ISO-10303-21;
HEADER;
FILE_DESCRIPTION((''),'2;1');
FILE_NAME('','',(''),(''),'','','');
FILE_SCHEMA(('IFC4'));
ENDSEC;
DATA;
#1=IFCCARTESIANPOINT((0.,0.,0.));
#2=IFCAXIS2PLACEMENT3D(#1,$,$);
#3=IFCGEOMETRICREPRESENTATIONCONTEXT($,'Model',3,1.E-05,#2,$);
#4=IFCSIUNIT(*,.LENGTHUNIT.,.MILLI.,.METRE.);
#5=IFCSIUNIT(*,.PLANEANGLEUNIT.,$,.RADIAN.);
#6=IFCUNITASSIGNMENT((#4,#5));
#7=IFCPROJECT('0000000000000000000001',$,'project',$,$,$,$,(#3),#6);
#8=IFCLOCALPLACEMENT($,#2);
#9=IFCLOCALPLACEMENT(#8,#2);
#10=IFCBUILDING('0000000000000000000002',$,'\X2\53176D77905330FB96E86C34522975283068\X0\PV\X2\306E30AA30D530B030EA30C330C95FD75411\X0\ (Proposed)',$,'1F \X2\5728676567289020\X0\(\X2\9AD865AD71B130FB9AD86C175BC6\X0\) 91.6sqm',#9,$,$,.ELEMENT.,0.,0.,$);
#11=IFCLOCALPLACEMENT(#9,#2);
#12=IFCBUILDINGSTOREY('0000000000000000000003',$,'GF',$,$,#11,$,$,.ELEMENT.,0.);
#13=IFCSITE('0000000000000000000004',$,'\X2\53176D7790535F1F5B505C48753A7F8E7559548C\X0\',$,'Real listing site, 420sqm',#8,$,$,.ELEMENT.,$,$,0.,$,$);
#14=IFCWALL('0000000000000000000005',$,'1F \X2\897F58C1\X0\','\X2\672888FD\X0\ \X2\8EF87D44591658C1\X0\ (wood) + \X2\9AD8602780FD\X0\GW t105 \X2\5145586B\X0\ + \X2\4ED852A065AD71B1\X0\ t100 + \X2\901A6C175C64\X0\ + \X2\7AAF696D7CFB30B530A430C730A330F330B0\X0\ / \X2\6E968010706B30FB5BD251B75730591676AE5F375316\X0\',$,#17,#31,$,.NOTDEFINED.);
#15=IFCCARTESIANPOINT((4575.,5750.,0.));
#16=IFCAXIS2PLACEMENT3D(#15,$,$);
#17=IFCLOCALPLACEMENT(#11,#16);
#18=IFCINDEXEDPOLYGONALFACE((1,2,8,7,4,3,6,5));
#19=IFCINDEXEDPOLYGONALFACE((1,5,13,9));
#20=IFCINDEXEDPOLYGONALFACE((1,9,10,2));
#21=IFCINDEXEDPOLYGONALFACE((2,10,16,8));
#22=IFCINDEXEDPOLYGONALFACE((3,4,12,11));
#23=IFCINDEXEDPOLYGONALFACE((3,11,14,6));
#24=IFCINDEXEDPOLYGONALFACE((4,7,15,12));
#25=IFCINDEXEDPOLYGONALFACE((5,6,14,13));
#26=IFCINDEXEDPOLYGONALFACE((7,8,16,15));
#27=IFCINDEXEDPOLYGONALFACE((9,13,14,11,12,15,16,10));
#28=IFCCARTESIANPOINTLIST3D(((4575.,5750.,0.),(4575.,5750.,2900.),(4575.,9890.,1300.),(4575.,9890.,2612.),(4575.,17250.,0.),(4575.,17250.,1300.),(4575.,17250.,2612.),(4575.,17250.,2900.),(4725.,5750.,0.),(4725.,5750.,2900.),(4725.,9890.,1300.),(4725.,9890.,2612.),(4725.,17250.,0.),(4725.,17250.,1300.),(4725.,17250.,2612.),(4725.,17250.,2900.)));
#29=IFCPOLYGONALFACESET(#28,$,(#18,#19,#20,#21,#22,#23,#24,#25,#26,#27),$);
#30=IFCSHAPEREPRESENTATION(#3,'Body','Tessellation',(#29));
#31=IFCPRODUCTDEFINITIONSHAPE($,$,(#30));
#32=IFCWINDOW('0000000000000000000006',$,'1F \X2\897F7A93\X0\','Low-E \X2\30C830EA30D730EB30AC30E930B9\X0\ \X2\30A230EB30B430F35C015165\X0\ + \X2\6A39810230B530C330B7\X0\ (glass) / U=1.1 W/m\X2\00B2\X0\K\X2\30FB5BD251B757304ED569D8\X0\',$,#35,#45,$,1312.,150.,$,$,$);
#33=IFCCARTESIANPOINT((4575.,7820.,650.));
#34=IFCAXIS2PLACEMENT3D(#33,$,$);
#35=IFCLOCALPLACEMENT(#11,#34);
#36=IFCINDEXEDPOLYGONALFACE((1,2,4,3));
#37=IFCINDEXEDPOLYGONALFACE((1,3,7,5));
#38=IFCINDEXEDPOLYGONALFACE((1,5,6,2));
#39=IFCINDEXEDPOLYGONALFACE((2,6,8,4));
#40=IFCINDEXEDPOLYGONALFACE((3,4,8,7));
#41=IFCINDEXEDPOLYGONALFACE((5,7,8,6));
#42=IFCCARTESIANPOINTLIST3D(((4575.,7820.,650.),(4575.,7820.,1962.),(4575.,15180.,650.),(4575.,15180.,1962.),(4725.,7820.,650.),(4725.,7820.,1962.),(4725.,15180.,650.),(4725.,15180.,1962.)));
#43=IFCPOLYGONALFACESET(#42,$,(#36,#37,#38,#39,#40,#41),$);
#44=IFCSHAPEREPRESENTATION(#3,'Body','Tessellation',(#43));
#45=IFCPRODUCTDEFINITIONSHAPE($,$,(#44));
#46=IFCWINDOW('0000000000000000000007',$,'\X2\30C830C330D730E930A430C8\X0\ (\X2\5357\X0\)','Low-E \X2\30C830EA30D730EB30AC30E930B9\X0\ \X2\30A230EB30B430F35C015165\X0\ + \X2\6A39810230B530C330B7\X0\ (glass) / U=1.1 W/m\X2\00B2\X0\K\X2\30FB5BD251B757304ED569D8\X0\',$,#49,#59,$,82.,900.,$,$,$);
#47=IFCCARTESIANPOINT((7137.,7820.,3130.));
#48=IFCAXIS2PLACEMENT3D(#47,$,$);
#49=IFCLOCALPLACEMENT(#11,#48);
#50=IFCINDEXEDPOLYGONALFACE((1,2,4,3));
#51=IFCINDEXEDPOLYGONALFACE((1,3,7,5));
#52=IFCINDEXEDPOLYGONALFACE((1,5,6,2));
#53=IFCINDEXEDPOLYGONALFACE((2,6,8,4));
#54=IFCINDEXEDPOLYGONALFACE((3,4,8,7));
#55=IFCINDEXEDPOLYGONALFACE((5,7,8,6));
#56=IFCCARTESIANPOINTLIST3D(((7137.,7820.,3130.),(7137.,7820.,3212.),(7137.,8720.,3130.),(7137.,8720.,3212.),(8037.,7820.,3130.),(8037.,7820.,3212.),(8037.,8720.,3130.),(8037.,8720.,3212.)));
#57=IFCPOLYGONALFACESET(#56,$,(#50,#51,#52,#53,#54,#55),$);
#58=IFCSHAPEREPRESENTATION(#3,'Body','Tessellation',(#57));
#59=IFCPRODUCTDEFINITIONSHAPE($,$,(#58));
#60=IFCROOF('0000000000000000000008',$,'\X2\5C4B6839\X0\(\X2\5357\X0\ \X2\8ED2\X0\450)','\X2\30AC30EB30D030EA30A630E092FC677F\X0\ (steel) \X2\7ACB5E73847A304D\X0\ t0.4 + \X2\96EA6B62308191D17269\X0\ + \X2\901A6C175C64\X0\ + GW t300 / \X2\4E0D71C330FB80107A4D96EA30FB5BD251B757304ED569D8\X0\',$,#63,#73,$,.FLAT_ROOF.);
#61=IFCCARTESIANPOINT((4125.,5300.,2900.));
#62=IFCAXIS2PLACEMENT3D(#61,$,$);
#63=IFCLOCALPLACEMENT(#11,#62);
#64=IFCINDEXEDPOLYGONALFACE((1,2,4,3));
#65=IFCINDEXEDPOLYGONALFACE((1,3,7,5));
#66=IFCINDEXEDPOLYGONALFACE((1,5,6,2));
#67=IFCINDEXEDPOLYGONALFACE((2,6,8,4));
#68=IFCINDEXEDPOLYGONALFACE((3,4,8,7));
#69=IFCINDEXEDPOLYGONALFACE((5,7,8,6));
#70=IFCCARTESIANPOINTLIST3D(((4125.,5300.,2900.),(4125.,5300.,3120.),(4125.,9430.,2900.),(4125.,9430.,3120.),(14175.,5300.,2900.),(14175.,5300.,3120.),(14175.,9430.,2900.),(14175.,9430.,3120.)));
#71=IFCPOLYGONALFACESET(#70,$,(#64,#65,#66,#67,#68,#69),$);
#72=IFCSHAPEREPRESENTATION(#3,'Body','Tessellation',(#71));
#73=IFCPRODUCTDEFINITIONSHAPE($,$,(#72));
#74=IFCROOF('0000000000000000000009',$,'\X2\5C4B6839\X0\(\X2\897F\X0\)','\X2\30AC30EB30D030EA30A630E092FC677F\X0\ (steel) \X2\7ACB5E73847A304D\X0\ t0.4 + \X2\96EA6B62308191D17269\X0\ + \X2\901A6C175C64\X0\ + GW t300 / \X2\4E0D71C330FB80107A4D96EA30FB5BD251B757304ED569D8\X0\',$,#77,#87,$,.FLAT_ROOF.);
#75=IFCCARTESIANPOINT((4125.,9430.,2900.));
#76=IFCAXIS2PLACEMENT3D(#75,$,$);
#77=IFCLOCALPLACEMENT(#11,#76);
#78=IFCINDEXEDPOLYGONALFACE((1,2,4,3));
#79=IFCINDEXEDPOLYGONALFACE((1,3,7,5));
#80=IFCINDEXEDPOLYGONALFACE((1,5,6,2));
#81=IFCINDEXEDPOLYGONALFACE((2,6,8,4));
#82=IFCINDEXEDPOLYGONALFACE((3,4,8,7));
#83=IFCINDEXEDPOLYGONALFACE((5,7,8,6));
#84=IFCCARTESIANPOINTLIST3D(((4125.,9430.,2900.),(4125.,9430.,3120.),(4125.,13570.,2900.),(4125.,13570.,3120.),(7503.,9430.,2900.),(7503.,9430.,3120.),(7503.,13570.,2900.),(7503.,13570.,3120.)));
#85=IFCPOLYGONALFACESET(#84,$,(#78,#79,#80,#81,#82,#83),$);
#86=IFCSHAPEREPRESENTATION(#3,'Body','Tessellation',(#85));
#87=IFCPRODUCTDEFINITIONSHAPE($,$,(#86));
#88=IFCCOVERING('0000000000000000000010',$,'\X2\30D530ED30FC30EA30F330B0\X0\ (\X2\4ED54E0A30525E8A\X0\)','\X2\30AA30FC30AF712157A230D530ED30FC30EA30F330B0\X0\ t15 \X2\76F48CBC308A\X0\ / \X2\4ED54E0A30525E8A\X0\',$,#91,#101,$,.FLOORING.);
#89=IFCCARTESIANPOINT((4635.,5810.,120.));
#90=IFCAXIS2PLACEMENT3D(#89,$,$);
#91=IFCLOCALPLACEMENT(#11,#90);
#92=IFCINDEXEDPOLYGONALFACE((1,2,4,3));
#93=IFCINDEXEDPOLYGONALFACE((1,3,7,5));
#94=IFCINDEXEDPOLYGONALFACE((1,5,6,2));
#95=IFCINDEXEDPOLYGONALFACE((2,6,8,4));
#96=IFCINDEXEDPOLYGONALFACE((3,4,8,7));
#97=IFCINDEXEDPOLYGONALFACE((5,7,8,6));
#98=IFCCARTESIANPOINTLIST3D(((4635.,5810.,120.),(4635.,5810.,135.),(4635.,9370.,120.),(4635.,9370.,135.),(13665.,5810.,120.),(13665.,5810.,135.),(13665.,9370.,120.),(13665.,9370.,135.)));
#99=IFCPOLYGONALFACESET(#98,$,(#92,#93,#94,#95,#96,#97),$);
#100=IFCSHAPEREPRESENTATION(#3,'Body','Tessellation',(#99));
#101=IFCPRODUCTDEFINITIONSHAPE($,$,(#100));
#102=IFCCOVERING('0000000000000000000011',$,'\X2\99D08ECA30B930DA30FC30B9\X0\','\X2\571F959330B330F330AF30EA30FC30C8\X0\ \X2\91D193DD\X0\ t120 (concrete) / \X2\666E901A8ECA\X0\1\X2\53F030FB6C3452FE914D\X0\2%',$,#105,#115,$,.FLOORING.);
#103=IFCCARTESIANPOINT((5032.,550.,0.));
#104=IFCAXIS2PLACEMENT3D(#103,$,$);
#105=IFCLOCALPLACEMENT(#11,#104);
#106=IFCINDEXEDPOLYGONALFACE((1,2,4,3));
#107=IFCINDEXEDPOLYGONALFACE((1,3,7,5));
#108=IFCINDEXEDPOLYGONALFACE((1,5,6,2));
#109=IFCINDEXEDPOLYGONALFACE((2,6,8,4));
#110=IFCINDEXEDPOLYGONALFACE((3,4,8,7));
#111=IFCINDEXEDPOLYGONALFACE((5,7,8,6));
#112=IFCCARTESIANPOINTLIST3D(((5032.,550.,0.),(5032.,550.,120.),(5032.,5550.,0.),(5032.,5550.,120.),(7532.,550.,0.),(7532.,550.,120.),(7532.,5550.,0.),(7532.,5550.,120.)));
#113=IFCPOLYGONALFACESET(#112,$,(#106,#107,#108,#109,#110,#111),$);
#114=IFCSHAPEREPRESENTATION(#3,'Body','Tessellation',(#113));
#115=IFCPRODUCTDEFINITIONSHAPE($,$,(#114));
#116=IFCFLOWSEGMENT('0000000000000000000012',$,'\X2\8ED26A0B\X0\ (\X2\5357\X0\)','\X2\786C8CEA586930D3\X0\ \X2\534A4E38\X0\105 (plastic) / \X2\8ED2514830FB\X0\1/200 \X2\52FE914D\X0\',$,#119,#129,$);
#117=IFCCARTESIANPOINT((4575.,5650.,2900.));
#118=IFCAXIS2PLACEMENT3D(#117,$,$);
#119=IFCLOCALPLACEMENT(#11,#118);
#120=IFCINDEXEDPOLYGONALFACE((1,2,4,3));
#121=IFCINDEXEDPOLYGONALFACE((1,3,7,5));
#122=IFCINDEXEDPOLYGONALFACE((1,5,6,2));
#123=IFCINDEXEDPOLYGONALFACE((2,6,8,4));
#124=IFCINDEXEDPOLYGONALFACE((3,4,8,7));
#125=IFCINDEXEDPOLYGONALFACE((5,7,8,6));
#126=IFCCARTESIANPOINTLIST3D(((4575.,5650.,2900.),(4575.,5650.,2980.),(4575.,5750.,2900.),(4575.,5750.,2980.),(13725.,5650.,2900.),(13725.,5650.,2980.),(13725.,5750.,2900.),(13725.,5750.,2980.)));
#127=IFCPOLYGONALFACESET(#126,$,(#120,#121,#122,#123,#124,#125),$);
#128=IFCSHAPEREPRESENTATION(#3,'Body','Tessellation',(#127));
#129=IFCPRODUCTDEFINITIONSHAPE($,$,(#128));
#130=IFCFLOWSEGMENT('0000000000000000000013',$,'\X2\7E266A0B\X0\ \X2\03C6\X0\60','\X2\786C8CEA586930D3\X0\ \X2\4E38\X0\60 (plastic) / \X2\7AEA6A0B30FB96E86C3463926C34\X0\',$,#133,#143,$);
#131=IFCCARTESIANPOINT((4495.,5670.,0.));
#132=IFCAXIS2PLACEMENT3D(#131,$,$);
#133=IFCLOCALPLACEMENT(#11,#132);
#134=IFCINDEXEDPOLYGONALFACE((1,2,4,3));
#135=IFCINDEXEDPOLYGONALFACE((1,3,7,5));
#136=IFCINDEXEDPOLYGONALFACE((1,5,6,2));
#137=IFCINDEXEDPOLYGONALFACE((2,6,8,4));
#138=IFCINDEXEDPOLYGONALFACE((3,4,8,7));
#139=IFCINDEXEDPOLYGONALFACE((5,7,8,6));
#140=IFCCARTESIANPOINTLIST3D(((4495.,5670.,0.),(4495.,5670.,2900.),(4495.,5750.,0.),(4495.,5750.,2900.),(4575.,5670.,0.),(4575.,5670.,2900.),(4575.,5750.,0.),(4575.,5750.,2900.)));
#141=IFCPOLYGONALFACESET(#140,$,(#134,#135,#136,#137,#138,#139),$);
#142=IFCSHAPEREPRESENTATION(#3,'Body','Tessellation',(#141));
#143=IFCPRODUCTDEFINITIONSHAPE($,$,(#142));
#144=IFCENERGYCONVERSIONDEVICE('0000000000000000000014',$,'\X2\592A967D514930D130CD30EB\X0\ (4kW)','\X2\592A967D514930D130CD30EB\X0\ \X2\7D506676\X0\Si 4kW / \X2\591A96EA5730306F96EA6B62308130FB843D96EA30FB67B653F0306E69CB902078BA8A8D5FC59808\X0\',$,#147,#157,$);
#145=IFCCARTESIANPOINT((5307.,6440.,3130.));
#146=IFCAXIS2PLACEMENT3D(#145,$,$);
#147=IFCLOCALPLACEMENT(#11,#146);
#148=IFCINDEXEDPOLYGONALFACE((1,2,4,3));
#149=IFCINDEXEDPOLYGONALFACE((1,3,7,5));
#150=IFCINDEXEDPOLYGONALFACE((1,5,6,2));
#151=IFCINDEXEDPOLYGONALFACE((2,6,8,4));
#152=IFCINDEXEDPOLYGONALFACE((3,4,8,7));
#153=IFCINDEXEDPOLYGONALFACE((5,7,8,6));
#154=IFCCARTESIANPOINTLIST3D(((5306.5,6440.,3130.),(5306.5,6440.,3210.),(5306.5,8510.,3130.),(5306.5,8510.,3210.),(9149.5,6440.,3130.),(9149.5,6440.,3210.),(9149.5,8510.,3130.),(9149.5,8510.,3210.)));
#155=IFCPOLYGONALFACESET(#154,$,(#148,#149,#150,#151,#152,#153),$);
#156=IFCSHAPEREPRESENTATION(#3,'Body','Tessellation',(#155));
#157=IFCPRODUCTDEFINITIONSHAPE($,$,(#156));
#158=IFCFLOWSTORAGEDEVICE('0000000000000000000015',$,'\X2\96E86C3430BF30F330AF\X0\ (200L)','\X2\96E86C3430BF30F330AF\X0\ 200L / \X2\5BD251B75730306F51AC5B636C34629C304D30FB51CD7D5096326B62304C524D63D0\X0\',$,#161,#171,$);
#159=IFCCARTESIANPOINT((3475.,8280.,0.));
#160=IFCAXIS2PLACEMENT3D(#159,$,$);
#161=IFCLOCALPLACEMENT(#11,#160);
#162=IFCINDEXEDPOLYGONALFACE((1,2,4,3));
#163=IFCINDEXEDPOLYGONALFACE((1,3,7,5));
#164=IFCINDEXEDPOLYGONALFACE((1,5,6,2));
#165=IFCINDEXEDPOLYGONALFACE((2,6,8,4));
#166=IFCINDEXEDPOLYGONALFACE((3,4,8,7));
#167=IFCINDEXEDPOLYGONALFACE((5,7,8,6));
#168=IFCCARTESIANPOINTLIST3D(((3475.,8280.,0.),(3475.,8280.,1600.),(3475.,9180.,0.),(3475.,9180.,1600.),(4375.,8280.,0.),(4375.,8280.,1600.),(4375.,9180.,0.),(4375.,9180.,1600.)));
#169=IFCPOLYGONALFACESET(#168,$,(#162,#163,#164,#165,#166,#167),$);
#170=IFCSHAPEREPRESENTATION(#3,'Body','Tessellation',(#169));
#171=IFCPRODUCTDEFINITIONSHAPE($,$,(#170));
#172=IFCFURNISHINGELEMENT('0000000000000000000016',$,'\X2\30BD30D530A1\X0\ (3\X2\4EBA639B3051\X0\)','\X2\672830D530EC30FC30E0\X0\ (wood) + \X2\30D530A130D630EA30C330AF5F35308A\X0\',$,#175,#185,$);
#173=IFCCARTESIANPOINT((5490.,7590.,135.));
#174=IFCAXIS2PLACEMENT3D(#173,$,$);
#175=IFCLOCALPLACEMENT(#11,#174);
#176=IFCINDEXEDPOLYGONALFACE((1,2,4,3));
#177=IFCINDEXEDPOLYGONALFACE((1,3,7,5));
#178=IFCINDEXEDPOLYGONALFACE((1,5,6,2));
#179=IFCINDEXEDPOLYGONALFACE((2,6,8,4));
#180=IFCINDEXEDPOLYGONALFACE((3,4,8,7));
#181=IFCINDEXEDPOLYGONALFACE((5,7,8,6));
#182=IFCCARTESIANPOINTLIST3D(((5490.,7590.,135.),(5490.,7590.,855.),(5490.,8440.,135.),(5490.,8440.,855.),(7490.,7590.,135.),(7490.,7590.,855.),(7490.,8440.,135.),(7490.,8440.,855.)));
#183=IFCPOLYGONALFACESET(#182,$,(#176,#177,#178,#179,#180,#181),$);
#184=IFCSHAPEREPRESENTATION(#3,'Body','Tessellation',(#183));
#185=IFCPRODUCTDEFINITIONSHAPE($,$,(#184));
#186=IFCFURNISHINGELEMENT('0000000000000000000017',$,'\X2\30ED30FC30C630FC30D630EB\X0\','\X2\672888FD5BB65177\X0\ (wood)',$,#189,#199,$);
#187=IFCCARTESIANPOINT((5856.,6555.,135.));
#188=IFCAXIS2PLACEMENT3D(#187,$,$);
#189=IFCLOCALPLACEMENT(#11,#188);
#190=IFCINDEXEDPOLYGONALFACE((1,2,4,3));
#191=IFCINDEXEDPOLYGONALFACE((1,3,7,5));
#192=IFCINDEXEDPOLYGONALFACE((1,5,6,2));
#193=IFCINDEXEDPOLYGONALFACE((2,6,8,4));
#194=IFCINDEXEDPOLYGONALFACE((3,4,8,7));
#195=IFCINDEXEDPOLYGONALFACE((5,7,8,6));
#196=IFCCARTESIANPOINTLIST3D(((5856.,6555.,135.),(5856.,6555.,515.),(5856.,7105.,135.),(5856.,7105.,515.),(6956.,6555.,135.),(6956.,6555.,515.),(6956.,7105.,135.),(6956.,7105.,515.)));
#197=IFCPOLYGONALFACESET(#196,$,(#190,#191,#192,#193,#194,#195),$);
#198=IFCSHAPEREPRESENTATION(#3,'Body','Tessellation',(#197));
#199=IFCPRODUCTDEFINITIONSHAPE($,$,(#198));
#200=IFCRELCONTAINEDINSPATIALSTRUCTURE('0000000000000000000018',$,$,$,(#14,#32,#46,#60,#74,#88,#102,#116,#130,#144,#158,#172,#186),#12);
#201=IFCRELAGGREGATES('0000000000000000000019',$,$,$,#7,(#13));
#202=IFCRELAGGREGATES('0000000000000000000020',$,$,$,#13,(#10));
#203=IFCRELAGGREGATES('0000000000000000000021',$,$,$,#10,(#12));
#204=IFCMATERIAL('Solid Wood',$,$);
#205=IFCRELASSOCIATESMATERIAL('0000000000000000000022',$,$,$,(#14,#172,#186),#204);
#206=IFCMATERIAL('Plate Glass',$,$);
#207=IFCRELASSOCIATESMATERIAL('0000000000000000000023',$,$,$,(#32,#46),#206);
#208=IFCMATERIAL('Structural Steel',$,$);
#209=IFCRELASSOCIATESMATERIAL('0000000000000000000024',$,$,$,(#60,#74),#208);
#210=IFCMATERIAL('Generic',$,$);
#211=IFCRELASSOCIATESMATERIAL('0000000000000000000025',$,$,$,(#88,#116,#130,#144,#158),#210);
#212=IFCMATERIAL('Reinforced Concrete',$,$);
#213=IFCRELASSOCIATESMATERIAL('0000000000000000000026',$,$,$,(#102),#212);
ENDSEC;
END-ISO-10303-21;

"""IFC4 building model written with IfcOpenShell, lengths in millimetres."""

from ifc_helpers import new_model, si_unit, frame, frame_2d, origin, place, context, project, spatial, rectangle, extrude, material, element, fill, save


model = new_model("IFC4")

# Units and contexts
model_context = context("Model", 3, precision=1e-05, world=origin())
ifc_project = project(units=[si_unit("LENGTHUNIT", "METRE", prefix="MILLI"), si_unit("PLANEANGLEUNIT", "RADIAN")], contexts=[model_context])

# Site, building, storey
site_placement = place(None, origin())
site = spatial("IfcSite", under=ifc_project, at=site_placement, Name="北海道弟子屈町美留和", ObjectType="Real listing site, 420sqm", CompositionType="ELEMENT", RefElevation=0.0)
building_placement = place(site_placement, origin())
building = spatial("IfcBuilding", under=site, at=building_placement, Name="北海道・雨水利用とPVのオフグリッド志向 (Proposed)", ObjectType="1F 在来木造(高断熱・高気密) 91.6sqm", CompositionType="ELEMENT", ElevationOfRefHeight=0.0, ElevationOfTerrain=0.0)
storey_placement = place(building_placement, origin())
storey = spatial("IfcBuildingStorey", under=building, at=storey_placement, Name="GF", CompositionType="ELEMENT", Elevation=0.0)

# Shared definitions
ifc_material_1 = material(Name="Solid Wood")

# Shared definitions
ifc_material_2 = material(Name="Reinforced Concrete")

# Shared definitions
ifc_material_3 = material(Name="Plate Glass")

# Wall, opening, window
wall_1_placement = place(storey_placement, frame((4575.0, 5750.0, 0.0)))
wall_1 = element("IfcWall", 1, at=wall_1_placement, inside=storey, material=ifc_material_1, Name="1F 西壁", Description="木製 軸組外壁 (wood) + 高性能GW t105 充填 + 付加断熱 t100 + 通気層 + 窯業系サイディング / 準耐火・寒冷地外皮強化", PredefinedType="NOTDEFINED", context=model_context, shape_type="SweptSolid", body=[
    extrude(rectangle(XDim=150.0, YDim=11500.0, at=frame_2d((75.0, 5750.0))), frame((4575.0, 5750.0, 0.0)), (0.0, 0.0, 1.0), 2900.0),
])
opening_1_placement = place(storey_placement, frame((4575.0, 7820.0, 650.0)))
opening_1 = element("IfcOpeningElement", 2, at=opening_1_placement, cuts=wall_1, PredefinedType="NOTDEFINED", context=model_context, shape_type="SweptSolid", body=[
    extrude(rectangle(XDim=150.0, YDim=7360.0, at=frame_2d((75.0, 3680.0))), frame((4575.0, 7820.0, 650.0)), (0.0, 0.0, 1.0), 1312.0),
])
window_1_placement = place(storey_placement, frame((4575.0, 7820.0, 650.0)))
window_1 = element("IfcWindow", 3, at=window_1_placement, inside=storey, material=ifc_material_3, Name="1F 西窓", Description="Low-E トリプルガラス アルゴン封入 + 樹脂サッシ (glass) / U=1.1 W/m²K・寒冷地仕様", OverallHeight=1312.0, OverallWidth=150.0, context=model_context, shape_type="SweptSolid", body=[
    extrude(rectangle(XDim=150.0, YDim=7360.0, at=frame_2d((75.0, 3680.0))), frame((4575.0, 7820.0, 650.0)), (0.0, 0.0, 1.0), 1312.0),
])
fill(opening_1, window_1)

# Window
window_2_placement = place(storey_placement, frame((7137.0, 7820.0, 3130.0)))
element("IfcWindow", 4, at=window_2_placement, inside=storey, material=ifc_material_3, Name="トップライト (南)", Description="Low-E トリプルガラス アルゴン封入 + 樹脂サッシ (glass) / U=1.1 W/m²K・寒冷地仕様", OverallHeight=82.0, OverallWidth=900.0, context=model_context, shape_type="SweptSolid", body=[
    extrude(rectangle(XDim=900.0, YDim=900.0, at=frame_2d((450.0, 450.0))), frame((7137.0, 7820.0, 3130.0)), (0.0, 0.0, 1.0), 82.0),
])

# Roofs
ifc_material_4 = material(Name="Structural Steel")
roof_1_placement = place(storey_placement, frame((4125.0, 5300.0, 2900.0)))
element("IfcRoof", 5, at=roof_1_placement, inside=storey, material=ifc_material_4, Name="屋根(南 軒450)", Description="ガルバリウム鋼板 (steel) 立平葺き t0.4 + 雪止め金物 + 通気層 + GW t300 / 不燃・耐積雪・寒冷地仕様", PredefinedType="FLAT_ROOF", context=model_context, shape_type="SweptSolid", body=[
    extrude(rectangle(XDim=10050.0, YDim=4130.0, at=frame_2d((5025.0, 2065.0))), frame((4125.0, 5300.0, 2900.0)), (0.0, 0.0, 1.0), 220.0),
])
roof_2_placement = place(storey_placement, frame((4125.0, 9430.0, 2900.0)))
element("IfcRoof", 6, at=roof_2_placement, inside=storey, material=ifc_material_4, Name="屋根(西)", Description="ガルバリウム鋼板 (steel) 立平葺き t0.4 + 雪止め金物 + 通気層 + GW t300 / 不燃・耐積雪・寒冷地仕様", PredefinedType="FLAT_ROOF", context=model_context, shape_type="SweptSolid", body=[
    extrude(rectangle(XDim=3378.0, YDim=4140.0, at=frame_2d((1689.0, 2070.0))), frame((4125.0, 9430.0, 2900.0)), (0.0, 0.0, 1.0), 220.0),
])

# Coverings
ifc_material_5 = material(Name="Generic")
covering_1_placement = place(storey_placement, frame((4635.0, 5810.0, 120.0)))
element("IfcCovering", 7, at=covering_1_placement, inside=storey, material=ifc_material_5, Name="フローリング (仕上げ床)", Description="オーク無垢フローリング t15 直貼り / 仕上げ床", PredefinedType="FLOORING", context=model_context, shape_type="SweptSolid", body=[
    extrude(rectangle(XDim=9030.0, YDim=3560.0, at=frame_2d((4515.0, 1780.0))), frame((4635.0, 5810.0, 120.0)), (0.0, 0.0, 1.0), 15.0),
])
covering_2_placement = place(storey_placement, frame((5032.0, 550.0, 0.0)))
element("IfcCovering", 8, at=covering_2_placement, inside=storey, material=ifc_material_2, Name="駐車スペース", Description="土間コンクリート 金鏝 t120 (concrete) / 普通車1台・水勾配2%", PredefinedType="FLOORING", context=model_context, shape_type="SweptSolid", body=[
    extrude(rectangle(XDim=2500.0, YDim=5000.0, at=frame_2d((1250.0, 2500.0))), frame((5032.0, 550.0, 0.0)), (0.0, 0.0, 1.0), 120.0),
])

# Flow segments
flow_segment_1_placement = place(storey_placement, frame((4575.0, 5650.0, 2900.0)))
element("IfcFlowSegment", 9, at=flow_segment_1_placement, inside=storey, material=ifc_material_5, Name="軒樋 (南)", Description="硬質塩ビ 半丸105 (plastic) / 軒先・1/200 勾配", context=model_context, shape_type="SweptSolid", body=[
    extrude(rectangle(XDim=9150.0, YDim=100.0, at=frame_2d((4575.0, 50.0))), frame((4575.0, 5650.0, 2900.0)), (0.0, 0.0, 1.0), 80.0),
])
flow_segment_2_placement = place(storey_placement, frame((4495.0, 5670.0, 0.0)))
element("IfcFlowSegment", 10, at=flow_segment_2_placement, inside=storey, material=ifc_material_5, Name="縦樋 φ60", Description="硬質塩ビ 丸60 (plastic) / 竪樋・雨水排水", context=model_context, shape_type="SweptSolid", body=[
    extrude(rectangle(XDim=80.0, YDim=80.0, at=frame_2d((40.0, 40.0))), frame((4495.0, 5670.0, 0.0)), (0.0, 0.0, 1.0), 2900.0),
])

# Energy conversion device
energy_conversion_device_placement = place(storey_placement, frame((5307.0, 6440.0, 3130.0)))
element("IfcEnergyConversionDevice", 11, at=energy_conversion_device_placement, inside=storey, material=ifc_material_5, Name="太陽光パネル (4kW)", Description="太陽光パネル 結晶Si 4kW / 多雪地は雪止め・落雪・架台の構造確認必須", context=model_context, shape_type="SweptSolid", body=[
    extrude(rectangle(XDim=3843.0, YDim=2070.0, at=frame_2d((1921.0, 1035.0))), frame((5307.0, 6440.0, 3130.0)), (0.0, 0.0, 1.0), 80.0),
])

# Flow storage device
flow_storage_device_placement = place(storey_placement, frame((3475.0, 8280.0, 0.0)))
element("IfcFlowStorageDevice", 12, at=flow_storage_device_placement, inside=storey, material=ifc_material_5, Name="雨水タンク (200L)", Description="雨水タンク 200L / 寒冷地は冬季水抜き・凍結防止が前提", context=model_context, shape_type="SweptSolid", body=[
    extrude(rectangle(XDim=900.0, YDim=900.0, at=frame_2d((450.0, 450.0))), frame((3475.0, 8280.0, 0.0)), (0.0, 0.0, 1.0), 1600.0),
])

# Furnishing elements
furnishing_1_placement = place(storey_placement, frame((5490.0, 7590.0, 135.0)))
element("IfcFurnishingElement", 13, at=furnishing_1_placement, inside=storey, material=ifc_material_1, Name="ソファ (3人掛け)", Description="木フレーム (wood) + ファブリック張り", context=model_context, shape_type="SweptSolid", body=[
    extrude(rectangle(XDim=2000.0, YDim=850.0, at=frame_2d((1000.0, 425.0))), frame((5490.0, 7590.0, 135.0)), (0.0, 0.0, 1.0), 720.0),
])
furnishing_2_placement = place(storey_placement, frame((5856.0, 6555.0, 135.0)))
element("IfcFurnishingElement", 14, at=furnishing_2_placement, inside=storey, material=ifc_material_1, Name="ローテーブル", Description="木製家具 (wood)", context=model_context, shape_type="SweptSolid", body=[
    extrude(rectangle(XDim=1100.0, YDim=550.0, at=frame_2d((550.0, 275.0))), frame((5856.0, 6555.0, 135.0)), (0.0, 0.0, 1.0), 380.0),
])

save(model, "model.ifc")
